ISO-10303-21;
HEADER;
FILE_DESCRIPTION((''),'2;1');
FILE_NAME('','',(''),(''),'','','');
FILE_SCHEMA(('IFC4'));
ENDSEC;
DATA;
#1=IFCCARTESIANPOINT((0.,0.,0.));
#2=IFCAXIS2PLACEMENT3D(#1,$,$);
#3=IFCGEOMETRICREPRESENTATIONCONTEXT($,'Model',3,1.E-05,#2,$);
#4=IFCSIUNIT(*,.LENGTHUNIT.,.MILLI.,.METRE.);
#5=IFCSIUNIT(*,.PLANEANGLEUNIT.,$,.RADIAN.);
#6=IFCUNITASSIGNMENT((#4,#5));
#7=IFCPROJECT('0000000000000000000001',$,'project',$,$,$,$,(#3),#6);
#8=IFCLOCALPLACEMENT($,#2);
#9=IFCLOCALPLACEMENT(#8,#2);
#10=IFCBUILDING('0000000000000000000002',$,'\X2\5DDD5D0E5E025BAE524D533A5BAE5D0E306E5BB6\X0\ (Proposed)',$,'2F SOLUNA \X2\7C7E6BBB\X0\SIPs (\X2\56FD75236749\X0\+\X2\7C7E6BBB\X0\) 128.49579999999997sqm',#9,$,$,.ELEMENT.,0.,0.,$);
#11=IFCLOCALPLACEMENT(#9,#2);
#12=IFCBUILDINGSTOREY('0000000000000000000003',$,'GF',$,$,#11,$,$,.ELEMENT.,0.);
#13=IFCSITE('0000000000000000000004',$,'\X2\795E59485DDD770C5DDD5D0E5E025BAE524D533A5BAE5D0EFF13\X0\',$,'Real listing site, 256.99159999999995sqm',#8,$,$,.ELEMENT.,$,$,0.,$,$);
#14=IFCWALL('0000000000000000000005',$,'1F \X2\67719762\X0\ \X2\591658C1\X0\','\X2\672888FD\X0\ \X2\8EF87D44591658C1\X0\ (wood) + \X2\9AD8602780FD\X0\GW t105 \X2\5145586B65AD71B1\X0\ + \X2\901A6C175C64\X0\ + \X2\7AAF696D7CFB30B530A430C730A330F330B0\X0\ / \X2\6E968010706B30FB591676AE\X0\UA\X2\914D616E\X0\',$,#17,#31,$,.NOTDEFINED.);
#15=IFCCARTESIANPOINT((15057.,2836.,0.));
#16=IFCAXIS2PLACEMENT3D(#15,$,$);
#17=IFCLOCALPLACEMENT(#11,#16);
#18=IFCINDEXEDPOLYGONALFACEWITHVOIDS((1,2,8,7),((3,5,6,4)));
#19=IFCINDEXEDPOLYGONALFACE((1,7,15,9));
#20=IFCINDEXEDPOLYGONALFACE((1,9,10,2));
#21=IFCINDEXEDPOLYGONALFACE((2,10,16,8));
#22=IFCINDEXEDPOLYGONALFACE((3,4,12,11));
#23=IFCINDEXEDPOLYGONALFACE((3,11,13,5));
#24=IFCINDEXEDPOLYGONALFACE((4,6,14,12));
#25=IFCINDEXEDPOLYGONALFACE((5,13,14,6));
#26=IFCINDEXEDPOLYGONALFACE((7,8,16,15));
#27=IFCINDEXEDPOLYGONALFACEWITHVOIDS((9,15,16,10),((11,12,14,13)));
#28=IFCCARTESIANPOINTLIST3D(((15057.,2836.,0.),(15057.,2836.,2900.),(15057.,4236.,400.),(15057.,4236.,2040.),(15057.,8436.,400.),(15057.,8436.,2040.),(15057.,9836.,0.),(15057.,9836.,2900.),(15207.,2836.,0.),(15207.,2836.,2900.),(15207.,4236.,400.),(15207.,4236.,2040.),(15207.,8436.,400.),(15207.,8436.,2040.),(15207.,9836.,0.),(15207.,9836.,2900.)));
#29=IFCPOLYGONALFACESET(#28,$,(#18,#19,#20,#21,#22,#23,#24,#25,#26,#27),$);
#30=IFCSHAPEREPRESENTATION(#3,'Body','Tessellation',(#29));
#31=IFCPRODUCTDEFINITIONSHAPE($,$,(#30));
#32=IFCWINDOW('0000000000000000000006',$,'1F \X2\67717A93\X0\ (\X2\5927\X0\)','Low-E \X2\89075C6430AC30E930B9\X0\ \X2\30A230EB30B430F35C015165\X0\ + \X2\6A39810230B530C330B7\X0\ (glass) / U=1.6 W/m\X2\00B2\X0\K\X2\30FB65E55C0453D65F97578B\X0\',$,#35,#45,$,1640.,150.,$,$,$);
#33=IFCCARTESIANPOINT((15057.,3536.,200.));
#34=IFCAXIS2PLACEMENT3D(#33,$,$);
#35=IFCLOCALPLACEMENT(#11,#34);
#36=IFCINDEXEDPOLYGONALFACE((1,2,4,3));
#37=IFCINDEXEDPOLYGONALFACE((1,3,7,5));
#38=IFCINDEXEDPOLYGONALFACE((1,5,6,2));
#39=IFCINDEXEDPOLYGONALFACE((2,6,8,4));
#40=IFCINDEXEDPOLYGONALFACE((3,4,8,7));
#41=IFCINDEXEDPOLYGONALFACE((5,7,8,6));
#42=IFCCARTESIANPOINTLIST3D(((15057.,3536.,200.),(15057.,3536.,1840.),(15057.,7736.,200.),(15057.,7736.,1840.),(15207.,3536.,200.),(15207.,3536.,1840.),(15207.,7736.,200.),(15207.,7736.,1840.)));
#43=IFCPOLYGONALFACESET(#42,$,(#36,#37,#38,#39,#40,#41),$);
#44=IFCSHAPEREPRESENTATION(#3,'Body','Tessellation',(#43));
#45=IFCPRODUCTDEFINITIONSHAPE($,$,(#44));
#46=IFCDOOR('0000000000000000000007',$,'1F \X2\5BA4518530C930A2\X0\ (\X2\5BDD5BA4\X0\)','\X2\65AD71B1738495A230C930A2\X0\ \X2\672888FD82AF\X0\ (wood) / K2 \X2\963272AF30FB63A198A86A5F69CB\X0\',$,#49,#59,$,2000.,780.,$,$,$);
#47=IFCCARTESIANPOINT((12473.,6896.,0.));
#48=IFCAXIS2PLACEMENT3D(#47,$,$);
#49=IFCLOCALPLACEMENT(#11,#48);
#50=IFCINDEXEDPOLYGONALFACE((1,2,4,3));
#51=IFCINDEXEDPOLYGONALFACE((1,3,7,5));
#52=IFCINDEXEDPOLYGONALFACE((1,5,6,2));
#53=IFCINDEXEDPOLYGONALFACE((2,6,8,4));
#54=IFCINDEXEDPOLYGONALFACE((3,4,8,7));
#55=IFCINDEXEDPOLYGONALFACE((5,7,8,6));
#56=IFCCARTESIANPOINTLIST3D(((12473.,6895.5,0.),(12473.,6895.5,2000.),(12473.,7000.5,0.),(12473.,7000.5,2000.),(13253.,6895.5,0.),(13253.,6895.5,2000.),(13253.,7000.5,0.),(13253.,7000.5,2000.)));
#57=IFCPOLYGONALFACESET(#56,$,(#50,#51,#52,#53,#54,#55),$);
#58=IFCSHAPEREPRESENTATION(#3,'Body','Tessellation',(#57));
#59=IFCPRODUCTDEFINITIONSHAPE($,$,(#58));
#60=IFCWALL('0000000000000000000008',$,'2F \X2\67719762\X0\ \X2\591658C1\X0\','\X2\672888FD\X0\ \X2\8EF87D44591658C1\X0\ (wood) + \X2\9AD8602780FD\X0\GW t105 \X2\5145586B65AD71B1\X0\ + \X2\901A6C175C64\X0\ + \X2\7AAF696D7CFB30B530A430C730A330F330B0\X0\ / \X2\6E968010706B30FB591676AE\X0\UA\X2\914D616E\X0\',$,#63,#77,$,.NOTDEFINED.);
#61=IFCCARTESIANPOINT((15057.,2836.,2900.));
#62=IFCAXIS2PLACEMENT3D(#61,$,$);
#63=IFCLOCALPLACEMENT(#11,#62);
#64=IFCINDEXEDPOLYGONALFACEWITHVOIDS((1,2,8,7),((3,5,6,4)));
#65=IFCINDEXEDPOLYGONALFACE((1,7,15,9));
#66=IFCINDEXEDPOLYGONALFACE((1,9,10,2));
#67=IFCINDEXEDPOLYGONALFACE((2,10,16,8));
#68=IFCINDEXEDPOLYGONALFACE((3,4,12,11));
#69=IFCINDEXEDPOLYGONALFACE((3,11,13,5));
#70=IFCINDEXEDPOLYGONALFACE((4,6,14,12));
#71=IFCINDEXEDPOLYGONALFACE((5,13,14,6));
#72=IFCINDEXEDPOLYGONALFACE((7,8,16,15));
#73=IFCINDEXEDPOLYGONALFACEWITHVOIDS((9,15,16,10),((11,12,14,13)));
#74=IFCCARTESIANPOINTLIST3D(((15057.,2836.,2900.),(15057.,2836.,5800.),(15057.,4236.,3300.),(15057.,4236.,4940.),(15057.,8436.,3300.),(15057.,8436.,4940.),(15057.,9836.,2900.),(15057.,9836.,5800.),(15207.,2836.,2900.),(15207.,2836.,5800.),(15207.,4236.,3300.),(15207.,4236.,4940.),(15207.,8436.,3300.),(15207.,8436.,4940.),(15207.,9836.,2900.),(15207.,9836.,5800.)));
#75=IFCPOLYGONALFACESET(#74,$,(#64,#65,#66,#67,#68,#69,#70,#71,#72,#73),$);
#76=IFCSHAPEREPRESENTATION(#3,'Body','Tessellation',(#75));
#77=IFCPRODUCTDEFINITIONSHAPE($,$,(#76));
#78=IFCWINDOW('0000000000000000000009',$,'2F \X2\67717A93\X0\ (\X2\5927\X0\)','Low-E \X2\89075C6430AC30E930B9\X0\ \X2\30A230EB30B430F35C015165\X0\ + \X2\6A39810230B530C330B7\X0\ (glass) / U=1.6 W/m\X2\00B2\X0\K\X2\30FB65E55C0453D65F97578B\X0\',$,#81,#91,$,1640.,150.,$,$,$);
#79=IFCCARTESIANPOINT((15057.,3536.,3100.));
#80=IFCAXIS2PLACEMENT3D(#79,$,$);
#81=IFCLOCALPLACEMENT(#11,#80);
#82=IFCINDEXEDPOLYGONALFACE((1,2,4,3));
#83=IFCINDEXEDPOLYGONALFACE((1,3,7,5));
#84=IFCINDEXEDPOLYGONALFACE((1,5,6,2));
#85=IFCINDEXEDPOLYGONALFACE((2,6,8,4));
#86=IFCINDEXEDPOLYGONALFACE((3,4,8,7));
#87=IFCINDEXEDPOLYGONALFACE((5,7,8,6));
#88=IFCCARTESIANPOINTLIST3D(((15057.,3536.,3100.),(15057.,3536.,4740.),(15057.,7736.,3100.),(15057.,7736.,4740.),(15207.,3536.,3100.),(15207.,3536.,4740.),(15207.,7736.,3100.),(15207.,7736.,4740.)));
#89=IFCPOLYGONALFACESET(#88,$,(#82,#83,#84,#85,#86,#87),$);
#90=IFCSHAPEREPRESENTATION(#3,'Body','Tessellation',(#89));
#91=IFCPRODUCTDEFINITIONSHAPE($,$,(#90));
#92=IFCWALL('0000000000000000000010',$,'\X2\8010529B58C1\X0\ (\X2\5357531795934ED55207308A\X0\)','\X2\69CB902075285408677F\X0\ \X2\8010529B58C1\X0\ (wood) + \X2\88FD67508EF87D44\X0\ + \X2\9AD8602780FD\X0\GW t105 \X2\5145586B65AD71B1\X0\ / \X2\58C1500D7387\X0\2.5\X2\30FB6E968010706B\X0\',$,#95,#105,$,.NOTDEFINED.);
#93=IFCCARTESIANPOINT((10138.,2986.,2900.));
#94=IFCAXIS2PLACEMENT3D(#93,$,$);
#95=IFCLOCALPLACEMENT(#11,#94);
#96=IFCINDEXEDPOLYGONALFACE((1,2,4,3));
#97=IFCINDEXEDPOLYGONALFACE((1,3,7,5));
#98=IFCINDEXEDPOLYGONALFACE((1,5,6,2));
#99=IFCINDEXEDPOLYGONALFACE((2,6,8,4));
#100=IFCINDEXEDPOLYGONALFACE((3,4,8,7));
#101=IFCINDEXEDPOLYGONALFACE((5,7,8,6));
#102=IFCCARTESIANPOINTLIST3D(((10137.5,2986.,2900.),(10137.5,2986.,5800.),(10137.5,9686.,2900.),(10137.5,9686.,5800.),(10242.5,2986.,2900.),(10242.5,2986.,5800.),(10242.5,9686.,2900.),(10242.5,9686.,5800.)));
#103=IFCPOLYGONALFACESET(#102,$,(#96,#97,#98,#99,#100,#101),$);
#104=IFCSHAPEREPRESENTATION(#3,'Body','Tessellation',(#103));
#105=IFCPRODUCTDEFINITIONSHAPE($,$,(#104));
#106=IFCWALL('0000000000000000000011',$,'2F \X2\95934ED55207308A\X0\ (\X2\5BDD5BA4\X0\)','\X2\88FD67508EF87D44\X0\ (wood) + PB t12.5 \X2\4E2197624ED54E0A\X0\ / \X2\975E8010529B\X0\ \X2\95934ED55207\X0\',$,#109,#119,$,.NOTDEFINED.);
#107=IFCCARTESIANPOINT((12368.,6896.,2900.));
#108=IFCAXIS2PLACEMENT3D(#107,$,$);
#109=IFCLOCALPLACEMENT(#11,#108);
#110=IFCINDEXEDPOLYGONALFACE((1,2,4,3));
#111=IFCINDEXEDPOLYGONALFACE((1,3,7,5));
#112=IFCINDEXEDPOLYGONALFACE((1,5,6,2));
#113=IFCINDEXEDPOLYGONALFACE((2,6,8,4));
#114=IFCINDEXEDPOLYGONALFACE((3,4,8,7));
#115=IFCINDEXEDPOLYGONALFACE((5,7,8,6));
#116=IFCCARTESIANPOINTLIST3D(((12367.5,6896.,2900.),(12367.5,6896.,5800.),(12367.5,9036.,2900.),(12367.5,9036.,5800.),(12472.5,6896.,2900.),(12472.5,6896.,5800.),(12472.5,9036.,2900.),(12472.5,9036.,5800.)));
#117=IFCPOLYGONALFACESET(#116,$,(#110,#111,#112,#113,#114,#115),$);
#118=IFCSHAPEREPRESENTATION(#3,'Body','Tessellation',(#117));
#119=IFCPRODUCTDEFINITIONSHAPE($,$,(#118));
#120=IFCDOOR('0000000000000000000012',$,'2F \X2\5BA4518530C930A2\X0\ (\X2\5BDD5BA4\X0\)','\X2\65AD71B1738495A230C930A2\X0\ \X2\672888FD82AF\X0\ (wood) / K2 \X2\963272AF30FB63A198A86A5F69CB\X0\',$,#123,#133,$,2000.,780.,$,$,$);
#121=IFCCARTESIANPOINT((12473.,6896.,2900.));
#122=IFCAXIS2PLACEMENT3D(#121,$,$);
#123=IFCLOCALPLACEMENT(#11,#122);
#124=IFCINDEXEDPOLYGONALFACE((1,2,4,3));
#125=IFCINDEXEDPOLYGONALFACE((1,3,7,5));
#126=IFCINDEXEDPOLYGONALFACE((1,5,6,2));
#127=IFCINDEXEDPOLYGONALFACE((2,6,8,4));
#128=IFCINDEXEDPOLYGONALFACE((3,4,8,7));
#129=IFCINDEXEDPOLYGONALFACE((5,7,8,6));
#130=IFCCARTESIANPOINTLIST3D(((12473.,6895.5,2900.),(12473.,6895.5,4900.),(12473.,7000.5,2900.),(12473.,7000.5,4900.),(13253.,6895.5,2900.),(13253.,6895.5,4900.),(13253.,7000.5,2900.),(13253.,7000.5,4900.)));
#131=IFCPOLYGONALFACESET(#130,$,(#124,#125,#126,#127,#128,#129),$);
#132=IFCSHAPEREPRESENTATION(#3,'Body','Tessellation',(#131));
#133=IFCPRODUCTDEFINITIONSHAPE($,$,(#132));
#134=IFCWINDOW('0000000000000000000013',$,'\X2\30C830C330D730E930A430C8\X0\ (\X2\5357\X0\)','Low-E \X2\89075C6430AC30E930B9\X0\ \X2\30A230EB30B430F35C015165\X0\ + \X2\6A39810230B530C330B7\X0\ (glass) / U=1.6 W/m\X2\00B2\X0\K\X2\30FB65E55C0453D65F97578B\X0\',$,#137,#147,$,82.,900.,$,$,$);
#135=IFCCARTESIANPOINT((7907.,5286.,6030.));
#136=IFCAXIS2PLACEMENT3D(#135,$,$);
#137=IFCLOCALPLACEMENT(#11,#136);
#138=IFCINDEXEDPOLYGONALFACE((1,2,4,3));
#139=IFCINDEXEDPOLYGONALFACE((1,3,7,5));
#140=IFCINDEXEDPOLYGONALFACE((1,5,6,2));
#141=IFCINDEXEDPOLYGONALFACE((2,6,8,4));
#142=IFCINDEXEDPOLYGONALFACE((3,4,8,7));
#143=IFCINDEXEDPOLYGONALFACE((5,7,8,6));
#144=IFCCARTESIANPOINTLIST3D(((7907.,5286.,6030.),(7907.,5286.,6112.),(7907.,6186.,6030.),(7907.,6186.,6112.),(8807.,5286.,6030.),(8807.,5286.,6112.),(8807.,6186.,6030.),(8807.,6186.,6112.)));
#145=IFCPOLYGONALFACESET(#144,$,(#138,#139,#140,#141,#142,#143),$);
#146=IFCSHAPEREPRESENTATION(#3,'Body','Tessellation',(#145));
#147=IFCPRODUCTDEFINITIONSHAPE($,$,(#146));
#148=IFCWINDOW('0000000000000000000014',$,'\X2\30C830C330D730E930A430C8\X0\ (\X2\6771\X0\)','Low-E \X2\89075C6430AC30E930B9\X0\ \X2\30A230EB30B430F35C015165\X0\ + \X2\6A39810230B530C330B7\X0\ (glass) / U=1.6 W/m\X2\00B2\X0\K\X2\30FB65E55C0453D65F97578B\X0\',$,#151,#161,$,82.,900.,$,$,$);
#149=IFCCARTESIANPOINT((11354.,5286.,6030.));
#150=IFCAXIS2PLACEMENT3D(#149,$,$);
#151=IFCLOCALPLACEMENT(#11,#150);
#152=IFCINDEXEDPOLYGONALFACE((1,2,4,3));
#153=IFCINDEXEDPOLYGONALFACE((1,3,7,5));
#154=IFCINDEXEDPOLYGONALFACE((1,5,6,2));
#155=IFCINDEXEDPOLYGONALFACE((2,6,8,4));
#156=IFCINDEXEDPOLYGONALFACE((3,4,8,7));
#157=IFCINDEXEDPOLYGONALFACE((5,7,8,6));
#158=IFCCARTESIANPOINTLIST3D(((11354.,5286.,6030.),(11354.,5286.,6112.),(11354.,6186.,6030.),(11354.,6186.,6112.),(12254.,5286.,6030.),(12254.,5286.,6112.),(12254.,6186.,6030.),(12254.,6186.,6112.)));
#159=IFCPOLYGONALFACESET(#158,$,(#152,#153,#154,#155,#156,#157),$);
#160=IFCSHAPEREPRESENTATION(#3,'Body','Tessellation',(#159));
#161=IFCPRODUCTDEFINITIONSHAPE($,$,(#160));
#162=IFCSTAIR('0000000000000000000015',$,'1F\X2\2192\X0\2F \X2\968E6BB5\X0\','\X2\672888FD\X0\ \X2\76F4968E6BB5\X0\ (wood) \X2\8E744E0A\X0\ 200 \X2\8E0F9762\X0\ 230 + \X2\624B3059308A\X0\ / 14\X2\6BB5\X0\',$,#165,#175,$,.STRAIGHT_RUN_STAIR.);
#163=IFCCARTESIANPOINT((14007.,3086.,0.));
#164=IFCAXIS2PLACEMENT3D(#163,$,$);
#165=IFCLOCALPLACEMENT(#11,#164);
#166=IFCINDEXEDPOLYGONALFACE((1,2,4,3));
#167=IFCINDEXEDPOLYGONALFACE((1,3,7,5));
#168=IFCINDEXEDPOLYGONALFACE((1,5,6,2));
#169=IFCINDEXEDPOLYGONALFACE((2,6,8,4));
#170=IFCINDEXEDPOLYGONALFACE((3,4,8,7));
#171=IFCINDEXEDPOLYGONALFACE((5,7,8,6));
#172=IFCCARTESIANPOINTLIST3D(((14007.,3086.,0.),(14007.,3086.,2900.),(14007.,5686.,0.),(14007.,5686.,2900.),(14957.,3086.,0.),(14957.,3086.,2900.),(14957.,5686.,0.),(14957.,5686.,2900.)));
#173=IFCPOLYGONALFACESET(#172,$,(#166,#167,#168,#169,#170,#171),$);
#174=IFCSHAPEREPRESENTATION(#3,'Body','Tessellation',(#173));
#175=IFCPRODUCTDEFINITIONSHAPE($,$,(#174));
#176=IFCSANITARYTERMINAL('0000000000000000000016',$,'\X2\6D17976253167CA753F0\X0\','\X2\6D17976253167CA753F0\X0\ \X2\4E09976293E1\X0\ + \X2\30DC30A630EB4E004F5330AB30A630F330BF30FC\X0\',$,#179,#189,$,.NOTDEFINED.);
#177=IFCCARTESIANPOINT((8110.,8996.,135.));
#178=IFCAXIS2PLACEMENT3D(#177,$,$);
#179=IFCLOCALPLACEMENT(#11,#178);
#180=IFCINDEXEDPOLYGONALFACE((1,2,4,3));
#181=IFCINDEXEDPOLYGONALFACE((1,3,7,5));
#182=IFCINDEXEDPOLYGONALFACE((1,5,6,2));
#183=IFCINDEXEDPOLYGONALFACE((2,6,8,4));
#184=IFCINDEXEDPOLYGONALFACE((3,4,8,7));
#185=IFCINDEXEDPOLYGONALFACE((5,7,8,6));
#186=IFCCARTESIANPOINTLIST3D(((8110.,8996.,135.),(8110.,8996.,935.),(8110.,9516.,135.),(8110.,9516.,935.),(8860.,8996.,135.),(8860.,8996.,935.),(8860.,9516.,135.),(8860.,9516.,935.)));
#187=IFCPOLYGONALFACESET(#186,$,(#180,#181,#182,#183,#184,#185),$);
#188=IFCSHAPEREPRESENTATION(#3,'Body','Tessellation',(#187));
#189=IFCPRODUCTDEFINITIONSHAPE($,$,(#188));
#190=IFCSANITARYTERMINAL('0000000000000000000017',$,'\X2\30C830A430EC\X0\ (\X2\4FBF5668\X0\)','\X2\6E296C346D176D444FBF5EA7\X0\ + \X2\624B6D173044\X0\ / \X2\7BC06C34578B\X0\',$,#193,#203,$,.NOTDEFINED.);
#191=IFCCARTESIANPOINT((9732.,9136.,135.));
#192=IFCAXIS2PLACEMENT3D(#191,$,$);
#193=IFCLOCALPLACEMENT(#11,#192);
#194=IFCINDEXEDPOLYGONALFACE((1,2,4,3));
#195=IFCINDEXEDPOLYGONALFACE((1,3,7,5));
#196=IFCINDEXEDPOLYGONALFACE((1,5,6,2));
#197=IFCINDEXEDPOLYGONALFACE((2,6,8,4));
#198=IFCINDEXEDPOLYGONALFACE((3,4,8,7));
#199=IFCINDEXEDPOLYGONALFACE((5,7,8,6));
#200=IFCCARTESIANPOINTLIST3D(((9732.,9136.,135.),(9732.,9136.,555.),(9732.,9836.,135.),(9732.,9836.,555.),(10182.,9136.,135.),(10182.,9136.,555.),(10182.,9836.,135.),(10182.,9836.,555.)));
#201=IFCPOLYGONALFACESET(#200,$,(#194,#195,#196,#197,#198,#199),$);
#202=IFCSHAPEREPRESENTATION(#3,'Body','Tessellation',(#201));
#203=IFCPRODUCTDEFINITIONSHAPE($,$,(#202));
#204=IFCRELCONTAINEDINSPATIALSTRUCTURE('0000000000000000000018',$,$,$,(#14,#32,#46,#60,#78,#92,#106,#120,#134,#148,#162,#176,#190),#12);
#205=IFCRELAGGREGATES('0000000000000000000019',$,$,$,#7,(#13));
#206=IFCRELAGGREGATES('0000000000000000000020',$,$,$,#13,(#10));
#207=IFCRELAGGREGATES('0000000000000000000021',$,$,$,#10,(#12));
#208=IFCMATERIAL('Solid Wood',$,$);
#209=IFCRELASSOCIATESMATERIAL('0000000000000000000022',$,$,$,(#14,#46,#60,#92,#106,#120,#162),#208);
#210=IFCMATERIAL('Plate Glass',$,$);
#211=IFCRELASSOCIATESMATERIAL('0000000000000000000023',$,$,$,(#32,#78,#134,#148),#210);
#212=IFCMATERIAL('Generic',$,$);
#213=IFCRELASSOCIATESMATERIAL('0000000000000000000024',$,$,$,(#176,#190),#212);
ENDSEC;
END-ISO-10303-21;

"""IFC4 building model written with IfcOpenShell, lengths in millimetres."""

from ifc_helpers import new_model, si_unit, frame, frame_2d, origin, place, context, project, spatial, rectangle, extrude, material, element, fill, save


model = new_model("IFC4")

# Units and contexts
model_context = context("Model", 3, precision=1e-05, world=origin())
ifc_project = project(units=[si_unit("LENGTHUNIT", "METRE", prefix="MILLI"), si_unit("PLANEANGLEUNIT", "RADIAN")], contexts=[model_context])

# Site, building, storey
site_placement = place(None, origin())
site = spatial("IfcSite", under=ifc_project, at=site_placement, Name="神奈川県川崎市宮前区宮崎３", ObjectType="Real listing site, 256.99159999999995sqm", CompositionType="ELEMENT", RefElevation=0.0)
building_placement = place(site_placement, origin())
building = spatial("IfcBuilding", under=site, at=building_placement, Name="川崎市宮前区宮崎の家 (Proposed)", ObjectType="2F SOLUNA 籾殻SIPs (国産杉+籾殻) 128.49579999999997sqm", CompositionType="ELEMENT", ElevationOfRefHeight=0.0, ElevationOfTerrain=0.0)
storey_placement = place(building_placement, origin())
storey = spatial("IfcBuildingStorey", under=building, at=storey_placement, Name="GF", CompositionType="ELEMENT", Elevation=0.0)

# Wall, opening, window
ifc_material_1 = material(Name="Solid Wood")
wall_1_placement = place(storey_placement, frame((15057.0, 2836.0, 0.0)))
wall_1 = element("IfcWall", 1, at=wall_1_placement, inside=storey, material=ifc_material_1, Name="1F 東面 外壁", Description="木製 軸組外壁 (wood) + 高性能GW t105 充填断熱 + 通気層 + 窯業系サイディング / 準耐火・外皮UA配慮", PredefinedType="NOTDEFINED", context=model_context, shape_type="SweptSolid", body=[
    extrude(rectangle(XDim=150.0, YDim=7000.0, at=frame_2d((75.0, 3500.0))), frame((15057.0, 2836.0, 0.0)), (0.0, 0.0, 1.0), 2900.0),
])
opening_1_placement = place(storey_placement, frame((15057.0, 3536.0, 200.0)))
opening_1 = element("IfcOpeningElement", 2, at=opening_1_placement, cuts=wall_1, PredefinedType="NOTDEFINED", context=model_context, shape_type="SweptSolid", body=[
    extrude(rectangle(XDim=150.0, YDim=4200.0, at=frame_2d((75.0, 2100.0))), frame((15057.0, 3536.0, 200.0)), (0.0, 0.0, 1.0), 1640.0),
])
ifc_material_2 = material(Name="Plate Glass")
window_1_placement = place(storey_placement, frame((15057.0, 3536.0, 200.0)))
window_1 = element("IfcWindow", 3, at=window_1_placement, inside=storey, material=ifc_material_2, Name="1F 東窓 (大)", Description="Low-E 複層ガラス アルゴン封入 + 樹脂サッシ (glass) / U=1.6 W/m²K・日射取得型", OverallHeight=1640.0, OverallWidth=150.0, context=model_context, shape_type="SweptSolid", body=[
    extrude(rectangle(XDim=150.0, YDim=4200.0, at=frame_2d((75.0, 2100.0))), frame((15057.0, 3536.0, 200.0)), (0.0, 0.0, 1.0), 1640.0),
])
fill(opening_1, window_1)

# Door
door_1_placement = place(storey_placement, frame((12473.0, 6896.0, 0.0)))
element("IfcDoor", 4, at=door_1_placement, inside=storey, material=ifc_material_1, Name="1F 室内ドア (寝室)", Description="断熱玄関ドア 木製芯 (wood) / K2 防犯・採風機構", OverallHeight=2000.0, OverallWidth=780.0, context=model_context, shape_type="SweptSolid", body=[
    extrude(rectangle(XDim=780.0, YDim=105.0, at=frame_2d((390.0, 52.0))), frame((12473.0, 6896.0, 0.0)), (0.0, 0.0, 1.0), 2000.0),
])

# Wall, opening, window
wall_2_placement = place(storey_placement, frame((15057.0, 2836.0, 2900.0)))
wall_2 = element("IfcWall", 5, at=wall_2_placement, inside=storey, material=ifc_material_1, Name="2F 東面 外壁", Description="木製 軸組外壁 (wood) + 高性能GW t105 充填断熱 + 通気層 + 窯業系サイディング / 準耐火・外皮UA配慮", PredefinedType="NOTDEFINED", context=model_context, shape_type="SweptSolid", body=[
    extrude(rectangle(XDim=150.0, YDim=7000.0, at=frame_2d((75.0, 3500.0))), frame((15057.0, 2836.0, 2900.0)), (0.0, 0.0, 1.0), 2900.0),
])
opening_2_placement = place(storey_placement, frame((15057.0, 3536.0, 3100.0)))
opening_2 = element("IfcOpeningElement", 6, at=opening_2_placement, cuts=wall_2, PredefinedType="NOTDEFINED", context=model_context, shape_type="SweptSolid", body=[
    extrude(rectangle(XDim=150.0, YDim=4200.0, at=frame_2d((75.0, 2100.0))), frame((15057.0, 3536.0, 3100.0)), (0.0, 0.0, 1.0), 1640.0),
])
window_2_placement = place(storey_placement, frame((15057.0, 3536.0, 3100.0)))
window_2 = element("IfcWindow", 7, at=window_2_placement, inside=storey, material=ifc_material_2, Name="2F 東窓 (大)", Description="Low-E 複層ガラス アルゴン封入 + 樹脂サッシ (glass) / U=1.6 W/m²K・日射取得型", OverallHeight=1640.0, OverallWidth=150.0, context=model_context, shape_type="SweptSolid", body=[
    extrude(rectangle(XDim=150.0, YDim=4200.0, at=frame_2d((75.0, 2100.0))), frame((15057.0, 3536.0, 3100.0)), (0.0, 0.0, 1.0), 1640.0),
])
fill(opening_2, window_2)

# Walls
wall_3_placement = place(storey_placement, frame((10138.0, 2986.0, 2900.0)))
element("IfcWall", 8, at=wall_3_placement, inside=storey, material=ifc_material_1, Name="耐力壁 (南北間仕切り)", Description="構造用合板 耐力壁 (wood) + 製材軸組 + 高性能GW t105 充填断熱 / 壁倍率2.5・準耐火", PredefinedType="NOTDEFINED", context=model_context, shape_type="SweptSolid", body=[
    extrude(rectangle(XDim=105.0, YDim=6700.0, at=frame_2d((52.0, 3350.0))), frame((10138.0, 2986.0, 2900.0)), (0.0, 0.0, 1.0), 2900.0),
])
wall_4_placement = place(storey_placement, frame((12368.0, 6896.0, 2900.0)))
element("IfcWall", 9, at=wall_4_placement, inside=storey, material=ifc_material_1, Name="2F 間仕切り (寝室)", Description="製材軸組 (wood) + PB t12.5 両面仕上 / 非耐力 間仕切", PredefinedType="NOTDEFINED", context=model_context, shape_type="SweptSolid", body=[
    extrude(rectangle(XDim=105.0, YDim=2140.0, at=frame_2d((52.0, 1070.0))), frame((12368.0, 6896.0, 2900.0)), (0.0, 0.0, 1.0), 2900.0),
])

# Door
door_2_placement = place(storey_placement, frame((12473.0, 6896.0, 2900.0)))
element("IfcDoor", 10, at=door_2_placement, inside=storey, material=ifc_material_1, Name="2F 室内ドア (寝室)", Description="断熱玄関ドア 木製芯 (wood) / K2 防犯・採風機構", OverallHeight=2000.0, OverallWidth=780.0, context=model_context, shape_type="SweptSolid", body=[
    extrude(rectangle(XDim=780.0, YDim=105.0, at=frame_2d((390.0, 52.0))), frame((12473.0, 6896.0, 2900.0)), (0.0, 0.0, 1.0), 2000.0),
])

# Windows
window_3_placement = place(storey_placement, frame((7907.0, 5286.0, 6030.0)))
element("IfcWindow", 11, at=window_3_placement, inside=storey, material=ifc_material_2, Name="トップライト (南)", Description="Low-E 複層ガラス アルゴン封入 + 樹脂サッシ (glass) / U=1.6 W/m²K・日射取得型", OverallHeight=82.0, OverallWidth=900.0, context=model_context, shape_type="SweptSolid", body=[
    extrude(rectangle(XDim=900.0, YDim=900.0, at=frame_2d((450.0, 450.0))), frame((7907.0, 5286.0, 6030.0)), (0.0, 0.0, 1.0), 82.0),
])
window_4_placement = place(storey_placement, frame((11354.0, 5286.0, 6030.0)))
element("IfcWindow", 12, at=window_4_placement, inside=storey, material=ifc_material_2, Name="トップライト (東)", Description="Low-E 複層ガラス アルゴン封入 + 樹脂サッシ (glass) / U=1.6 W/m²K・日射取得型", OverallHeight=82.0, OverallWidth=900.0, context=model_context, shape_type="SweptSolid", body=[
    extrude(rectangle(XDim=900.0, YDim=900.0, at=frame_2d((450.0, 450.0))), frame((11354.0, 5286.0, 6030.0)), (0.0, 0.0, 1.0), 82.0),
])

# Stair
stair_placement = place(storey_placement, frame((14007.0, 3086.0, 0.0)))
element("IfcStair", 13, at=stair_placement, inside=storey, material=ifc_material_1, Name="1F→2F 階段", Description="木製 直階段 (wood) 蹴上 200 踏面 230 + 手すり / 14段", PredefinedType="STRAIGHT_RUN_STAIR", context=model_context, shape_type="SweptSolid", body=[
    extrude(rectangle(XDim=950.0, YDim=2600.0, at=frame_2d((475.0, 1300.0))), frame((14007.0, 3086.0, 0.0)), (0.0, 0.0, 1.0), 2900.0),
])

# Sanitary terminals
ifc_material_3 = material(Name="Generic")
sanitary_terminal_1_placement = place(storey_placement, frame((8110.0, 8996.0, 135.0)))
element("IfcSanitaryTerminal", 14, at=sanitary_terminal_1_placement, inside=storey, material=ifc_material_3, Name="洗面化粧台", Description="洗面化粧台 三面鏡 + ボウル一体カウンター", PredefinedType="NOTDEFINED", context=model_context, shape_type="SweptSolid", body=[
    extrude(rectangle(XDim=750.0, YDim=520.0, at=frame_2d((375.0, 260.0))), frame((8110.0, 8996.0, 135.0)), (0.0, 0.0, 1.0), 800.0),
])
sanitary_terminal_2_placement = place(storey_placement, frame((9732.0, 9136.0, 135.0)))
element("IfcSanitaryTerminal", 15, at=sanitary_terminal_2_placement, inside=storey, material=ifc_material_3, Name="トイレ (便器)", Description="温水洗浄便座 + 手洗い / 節水型", PredefinedType="NOTDEFINED", context=model_context, shape_type="SweptSolid", body=[
    extrude(rectangle(XDim=450.0, YDim=700.0, at=frame_2d((225.0, 350.0))), frame((9732.0, 9136.0, 135.0)), (0.0, 0.0, 1.0), 420.0),
])

save(model, "model.ifc")
